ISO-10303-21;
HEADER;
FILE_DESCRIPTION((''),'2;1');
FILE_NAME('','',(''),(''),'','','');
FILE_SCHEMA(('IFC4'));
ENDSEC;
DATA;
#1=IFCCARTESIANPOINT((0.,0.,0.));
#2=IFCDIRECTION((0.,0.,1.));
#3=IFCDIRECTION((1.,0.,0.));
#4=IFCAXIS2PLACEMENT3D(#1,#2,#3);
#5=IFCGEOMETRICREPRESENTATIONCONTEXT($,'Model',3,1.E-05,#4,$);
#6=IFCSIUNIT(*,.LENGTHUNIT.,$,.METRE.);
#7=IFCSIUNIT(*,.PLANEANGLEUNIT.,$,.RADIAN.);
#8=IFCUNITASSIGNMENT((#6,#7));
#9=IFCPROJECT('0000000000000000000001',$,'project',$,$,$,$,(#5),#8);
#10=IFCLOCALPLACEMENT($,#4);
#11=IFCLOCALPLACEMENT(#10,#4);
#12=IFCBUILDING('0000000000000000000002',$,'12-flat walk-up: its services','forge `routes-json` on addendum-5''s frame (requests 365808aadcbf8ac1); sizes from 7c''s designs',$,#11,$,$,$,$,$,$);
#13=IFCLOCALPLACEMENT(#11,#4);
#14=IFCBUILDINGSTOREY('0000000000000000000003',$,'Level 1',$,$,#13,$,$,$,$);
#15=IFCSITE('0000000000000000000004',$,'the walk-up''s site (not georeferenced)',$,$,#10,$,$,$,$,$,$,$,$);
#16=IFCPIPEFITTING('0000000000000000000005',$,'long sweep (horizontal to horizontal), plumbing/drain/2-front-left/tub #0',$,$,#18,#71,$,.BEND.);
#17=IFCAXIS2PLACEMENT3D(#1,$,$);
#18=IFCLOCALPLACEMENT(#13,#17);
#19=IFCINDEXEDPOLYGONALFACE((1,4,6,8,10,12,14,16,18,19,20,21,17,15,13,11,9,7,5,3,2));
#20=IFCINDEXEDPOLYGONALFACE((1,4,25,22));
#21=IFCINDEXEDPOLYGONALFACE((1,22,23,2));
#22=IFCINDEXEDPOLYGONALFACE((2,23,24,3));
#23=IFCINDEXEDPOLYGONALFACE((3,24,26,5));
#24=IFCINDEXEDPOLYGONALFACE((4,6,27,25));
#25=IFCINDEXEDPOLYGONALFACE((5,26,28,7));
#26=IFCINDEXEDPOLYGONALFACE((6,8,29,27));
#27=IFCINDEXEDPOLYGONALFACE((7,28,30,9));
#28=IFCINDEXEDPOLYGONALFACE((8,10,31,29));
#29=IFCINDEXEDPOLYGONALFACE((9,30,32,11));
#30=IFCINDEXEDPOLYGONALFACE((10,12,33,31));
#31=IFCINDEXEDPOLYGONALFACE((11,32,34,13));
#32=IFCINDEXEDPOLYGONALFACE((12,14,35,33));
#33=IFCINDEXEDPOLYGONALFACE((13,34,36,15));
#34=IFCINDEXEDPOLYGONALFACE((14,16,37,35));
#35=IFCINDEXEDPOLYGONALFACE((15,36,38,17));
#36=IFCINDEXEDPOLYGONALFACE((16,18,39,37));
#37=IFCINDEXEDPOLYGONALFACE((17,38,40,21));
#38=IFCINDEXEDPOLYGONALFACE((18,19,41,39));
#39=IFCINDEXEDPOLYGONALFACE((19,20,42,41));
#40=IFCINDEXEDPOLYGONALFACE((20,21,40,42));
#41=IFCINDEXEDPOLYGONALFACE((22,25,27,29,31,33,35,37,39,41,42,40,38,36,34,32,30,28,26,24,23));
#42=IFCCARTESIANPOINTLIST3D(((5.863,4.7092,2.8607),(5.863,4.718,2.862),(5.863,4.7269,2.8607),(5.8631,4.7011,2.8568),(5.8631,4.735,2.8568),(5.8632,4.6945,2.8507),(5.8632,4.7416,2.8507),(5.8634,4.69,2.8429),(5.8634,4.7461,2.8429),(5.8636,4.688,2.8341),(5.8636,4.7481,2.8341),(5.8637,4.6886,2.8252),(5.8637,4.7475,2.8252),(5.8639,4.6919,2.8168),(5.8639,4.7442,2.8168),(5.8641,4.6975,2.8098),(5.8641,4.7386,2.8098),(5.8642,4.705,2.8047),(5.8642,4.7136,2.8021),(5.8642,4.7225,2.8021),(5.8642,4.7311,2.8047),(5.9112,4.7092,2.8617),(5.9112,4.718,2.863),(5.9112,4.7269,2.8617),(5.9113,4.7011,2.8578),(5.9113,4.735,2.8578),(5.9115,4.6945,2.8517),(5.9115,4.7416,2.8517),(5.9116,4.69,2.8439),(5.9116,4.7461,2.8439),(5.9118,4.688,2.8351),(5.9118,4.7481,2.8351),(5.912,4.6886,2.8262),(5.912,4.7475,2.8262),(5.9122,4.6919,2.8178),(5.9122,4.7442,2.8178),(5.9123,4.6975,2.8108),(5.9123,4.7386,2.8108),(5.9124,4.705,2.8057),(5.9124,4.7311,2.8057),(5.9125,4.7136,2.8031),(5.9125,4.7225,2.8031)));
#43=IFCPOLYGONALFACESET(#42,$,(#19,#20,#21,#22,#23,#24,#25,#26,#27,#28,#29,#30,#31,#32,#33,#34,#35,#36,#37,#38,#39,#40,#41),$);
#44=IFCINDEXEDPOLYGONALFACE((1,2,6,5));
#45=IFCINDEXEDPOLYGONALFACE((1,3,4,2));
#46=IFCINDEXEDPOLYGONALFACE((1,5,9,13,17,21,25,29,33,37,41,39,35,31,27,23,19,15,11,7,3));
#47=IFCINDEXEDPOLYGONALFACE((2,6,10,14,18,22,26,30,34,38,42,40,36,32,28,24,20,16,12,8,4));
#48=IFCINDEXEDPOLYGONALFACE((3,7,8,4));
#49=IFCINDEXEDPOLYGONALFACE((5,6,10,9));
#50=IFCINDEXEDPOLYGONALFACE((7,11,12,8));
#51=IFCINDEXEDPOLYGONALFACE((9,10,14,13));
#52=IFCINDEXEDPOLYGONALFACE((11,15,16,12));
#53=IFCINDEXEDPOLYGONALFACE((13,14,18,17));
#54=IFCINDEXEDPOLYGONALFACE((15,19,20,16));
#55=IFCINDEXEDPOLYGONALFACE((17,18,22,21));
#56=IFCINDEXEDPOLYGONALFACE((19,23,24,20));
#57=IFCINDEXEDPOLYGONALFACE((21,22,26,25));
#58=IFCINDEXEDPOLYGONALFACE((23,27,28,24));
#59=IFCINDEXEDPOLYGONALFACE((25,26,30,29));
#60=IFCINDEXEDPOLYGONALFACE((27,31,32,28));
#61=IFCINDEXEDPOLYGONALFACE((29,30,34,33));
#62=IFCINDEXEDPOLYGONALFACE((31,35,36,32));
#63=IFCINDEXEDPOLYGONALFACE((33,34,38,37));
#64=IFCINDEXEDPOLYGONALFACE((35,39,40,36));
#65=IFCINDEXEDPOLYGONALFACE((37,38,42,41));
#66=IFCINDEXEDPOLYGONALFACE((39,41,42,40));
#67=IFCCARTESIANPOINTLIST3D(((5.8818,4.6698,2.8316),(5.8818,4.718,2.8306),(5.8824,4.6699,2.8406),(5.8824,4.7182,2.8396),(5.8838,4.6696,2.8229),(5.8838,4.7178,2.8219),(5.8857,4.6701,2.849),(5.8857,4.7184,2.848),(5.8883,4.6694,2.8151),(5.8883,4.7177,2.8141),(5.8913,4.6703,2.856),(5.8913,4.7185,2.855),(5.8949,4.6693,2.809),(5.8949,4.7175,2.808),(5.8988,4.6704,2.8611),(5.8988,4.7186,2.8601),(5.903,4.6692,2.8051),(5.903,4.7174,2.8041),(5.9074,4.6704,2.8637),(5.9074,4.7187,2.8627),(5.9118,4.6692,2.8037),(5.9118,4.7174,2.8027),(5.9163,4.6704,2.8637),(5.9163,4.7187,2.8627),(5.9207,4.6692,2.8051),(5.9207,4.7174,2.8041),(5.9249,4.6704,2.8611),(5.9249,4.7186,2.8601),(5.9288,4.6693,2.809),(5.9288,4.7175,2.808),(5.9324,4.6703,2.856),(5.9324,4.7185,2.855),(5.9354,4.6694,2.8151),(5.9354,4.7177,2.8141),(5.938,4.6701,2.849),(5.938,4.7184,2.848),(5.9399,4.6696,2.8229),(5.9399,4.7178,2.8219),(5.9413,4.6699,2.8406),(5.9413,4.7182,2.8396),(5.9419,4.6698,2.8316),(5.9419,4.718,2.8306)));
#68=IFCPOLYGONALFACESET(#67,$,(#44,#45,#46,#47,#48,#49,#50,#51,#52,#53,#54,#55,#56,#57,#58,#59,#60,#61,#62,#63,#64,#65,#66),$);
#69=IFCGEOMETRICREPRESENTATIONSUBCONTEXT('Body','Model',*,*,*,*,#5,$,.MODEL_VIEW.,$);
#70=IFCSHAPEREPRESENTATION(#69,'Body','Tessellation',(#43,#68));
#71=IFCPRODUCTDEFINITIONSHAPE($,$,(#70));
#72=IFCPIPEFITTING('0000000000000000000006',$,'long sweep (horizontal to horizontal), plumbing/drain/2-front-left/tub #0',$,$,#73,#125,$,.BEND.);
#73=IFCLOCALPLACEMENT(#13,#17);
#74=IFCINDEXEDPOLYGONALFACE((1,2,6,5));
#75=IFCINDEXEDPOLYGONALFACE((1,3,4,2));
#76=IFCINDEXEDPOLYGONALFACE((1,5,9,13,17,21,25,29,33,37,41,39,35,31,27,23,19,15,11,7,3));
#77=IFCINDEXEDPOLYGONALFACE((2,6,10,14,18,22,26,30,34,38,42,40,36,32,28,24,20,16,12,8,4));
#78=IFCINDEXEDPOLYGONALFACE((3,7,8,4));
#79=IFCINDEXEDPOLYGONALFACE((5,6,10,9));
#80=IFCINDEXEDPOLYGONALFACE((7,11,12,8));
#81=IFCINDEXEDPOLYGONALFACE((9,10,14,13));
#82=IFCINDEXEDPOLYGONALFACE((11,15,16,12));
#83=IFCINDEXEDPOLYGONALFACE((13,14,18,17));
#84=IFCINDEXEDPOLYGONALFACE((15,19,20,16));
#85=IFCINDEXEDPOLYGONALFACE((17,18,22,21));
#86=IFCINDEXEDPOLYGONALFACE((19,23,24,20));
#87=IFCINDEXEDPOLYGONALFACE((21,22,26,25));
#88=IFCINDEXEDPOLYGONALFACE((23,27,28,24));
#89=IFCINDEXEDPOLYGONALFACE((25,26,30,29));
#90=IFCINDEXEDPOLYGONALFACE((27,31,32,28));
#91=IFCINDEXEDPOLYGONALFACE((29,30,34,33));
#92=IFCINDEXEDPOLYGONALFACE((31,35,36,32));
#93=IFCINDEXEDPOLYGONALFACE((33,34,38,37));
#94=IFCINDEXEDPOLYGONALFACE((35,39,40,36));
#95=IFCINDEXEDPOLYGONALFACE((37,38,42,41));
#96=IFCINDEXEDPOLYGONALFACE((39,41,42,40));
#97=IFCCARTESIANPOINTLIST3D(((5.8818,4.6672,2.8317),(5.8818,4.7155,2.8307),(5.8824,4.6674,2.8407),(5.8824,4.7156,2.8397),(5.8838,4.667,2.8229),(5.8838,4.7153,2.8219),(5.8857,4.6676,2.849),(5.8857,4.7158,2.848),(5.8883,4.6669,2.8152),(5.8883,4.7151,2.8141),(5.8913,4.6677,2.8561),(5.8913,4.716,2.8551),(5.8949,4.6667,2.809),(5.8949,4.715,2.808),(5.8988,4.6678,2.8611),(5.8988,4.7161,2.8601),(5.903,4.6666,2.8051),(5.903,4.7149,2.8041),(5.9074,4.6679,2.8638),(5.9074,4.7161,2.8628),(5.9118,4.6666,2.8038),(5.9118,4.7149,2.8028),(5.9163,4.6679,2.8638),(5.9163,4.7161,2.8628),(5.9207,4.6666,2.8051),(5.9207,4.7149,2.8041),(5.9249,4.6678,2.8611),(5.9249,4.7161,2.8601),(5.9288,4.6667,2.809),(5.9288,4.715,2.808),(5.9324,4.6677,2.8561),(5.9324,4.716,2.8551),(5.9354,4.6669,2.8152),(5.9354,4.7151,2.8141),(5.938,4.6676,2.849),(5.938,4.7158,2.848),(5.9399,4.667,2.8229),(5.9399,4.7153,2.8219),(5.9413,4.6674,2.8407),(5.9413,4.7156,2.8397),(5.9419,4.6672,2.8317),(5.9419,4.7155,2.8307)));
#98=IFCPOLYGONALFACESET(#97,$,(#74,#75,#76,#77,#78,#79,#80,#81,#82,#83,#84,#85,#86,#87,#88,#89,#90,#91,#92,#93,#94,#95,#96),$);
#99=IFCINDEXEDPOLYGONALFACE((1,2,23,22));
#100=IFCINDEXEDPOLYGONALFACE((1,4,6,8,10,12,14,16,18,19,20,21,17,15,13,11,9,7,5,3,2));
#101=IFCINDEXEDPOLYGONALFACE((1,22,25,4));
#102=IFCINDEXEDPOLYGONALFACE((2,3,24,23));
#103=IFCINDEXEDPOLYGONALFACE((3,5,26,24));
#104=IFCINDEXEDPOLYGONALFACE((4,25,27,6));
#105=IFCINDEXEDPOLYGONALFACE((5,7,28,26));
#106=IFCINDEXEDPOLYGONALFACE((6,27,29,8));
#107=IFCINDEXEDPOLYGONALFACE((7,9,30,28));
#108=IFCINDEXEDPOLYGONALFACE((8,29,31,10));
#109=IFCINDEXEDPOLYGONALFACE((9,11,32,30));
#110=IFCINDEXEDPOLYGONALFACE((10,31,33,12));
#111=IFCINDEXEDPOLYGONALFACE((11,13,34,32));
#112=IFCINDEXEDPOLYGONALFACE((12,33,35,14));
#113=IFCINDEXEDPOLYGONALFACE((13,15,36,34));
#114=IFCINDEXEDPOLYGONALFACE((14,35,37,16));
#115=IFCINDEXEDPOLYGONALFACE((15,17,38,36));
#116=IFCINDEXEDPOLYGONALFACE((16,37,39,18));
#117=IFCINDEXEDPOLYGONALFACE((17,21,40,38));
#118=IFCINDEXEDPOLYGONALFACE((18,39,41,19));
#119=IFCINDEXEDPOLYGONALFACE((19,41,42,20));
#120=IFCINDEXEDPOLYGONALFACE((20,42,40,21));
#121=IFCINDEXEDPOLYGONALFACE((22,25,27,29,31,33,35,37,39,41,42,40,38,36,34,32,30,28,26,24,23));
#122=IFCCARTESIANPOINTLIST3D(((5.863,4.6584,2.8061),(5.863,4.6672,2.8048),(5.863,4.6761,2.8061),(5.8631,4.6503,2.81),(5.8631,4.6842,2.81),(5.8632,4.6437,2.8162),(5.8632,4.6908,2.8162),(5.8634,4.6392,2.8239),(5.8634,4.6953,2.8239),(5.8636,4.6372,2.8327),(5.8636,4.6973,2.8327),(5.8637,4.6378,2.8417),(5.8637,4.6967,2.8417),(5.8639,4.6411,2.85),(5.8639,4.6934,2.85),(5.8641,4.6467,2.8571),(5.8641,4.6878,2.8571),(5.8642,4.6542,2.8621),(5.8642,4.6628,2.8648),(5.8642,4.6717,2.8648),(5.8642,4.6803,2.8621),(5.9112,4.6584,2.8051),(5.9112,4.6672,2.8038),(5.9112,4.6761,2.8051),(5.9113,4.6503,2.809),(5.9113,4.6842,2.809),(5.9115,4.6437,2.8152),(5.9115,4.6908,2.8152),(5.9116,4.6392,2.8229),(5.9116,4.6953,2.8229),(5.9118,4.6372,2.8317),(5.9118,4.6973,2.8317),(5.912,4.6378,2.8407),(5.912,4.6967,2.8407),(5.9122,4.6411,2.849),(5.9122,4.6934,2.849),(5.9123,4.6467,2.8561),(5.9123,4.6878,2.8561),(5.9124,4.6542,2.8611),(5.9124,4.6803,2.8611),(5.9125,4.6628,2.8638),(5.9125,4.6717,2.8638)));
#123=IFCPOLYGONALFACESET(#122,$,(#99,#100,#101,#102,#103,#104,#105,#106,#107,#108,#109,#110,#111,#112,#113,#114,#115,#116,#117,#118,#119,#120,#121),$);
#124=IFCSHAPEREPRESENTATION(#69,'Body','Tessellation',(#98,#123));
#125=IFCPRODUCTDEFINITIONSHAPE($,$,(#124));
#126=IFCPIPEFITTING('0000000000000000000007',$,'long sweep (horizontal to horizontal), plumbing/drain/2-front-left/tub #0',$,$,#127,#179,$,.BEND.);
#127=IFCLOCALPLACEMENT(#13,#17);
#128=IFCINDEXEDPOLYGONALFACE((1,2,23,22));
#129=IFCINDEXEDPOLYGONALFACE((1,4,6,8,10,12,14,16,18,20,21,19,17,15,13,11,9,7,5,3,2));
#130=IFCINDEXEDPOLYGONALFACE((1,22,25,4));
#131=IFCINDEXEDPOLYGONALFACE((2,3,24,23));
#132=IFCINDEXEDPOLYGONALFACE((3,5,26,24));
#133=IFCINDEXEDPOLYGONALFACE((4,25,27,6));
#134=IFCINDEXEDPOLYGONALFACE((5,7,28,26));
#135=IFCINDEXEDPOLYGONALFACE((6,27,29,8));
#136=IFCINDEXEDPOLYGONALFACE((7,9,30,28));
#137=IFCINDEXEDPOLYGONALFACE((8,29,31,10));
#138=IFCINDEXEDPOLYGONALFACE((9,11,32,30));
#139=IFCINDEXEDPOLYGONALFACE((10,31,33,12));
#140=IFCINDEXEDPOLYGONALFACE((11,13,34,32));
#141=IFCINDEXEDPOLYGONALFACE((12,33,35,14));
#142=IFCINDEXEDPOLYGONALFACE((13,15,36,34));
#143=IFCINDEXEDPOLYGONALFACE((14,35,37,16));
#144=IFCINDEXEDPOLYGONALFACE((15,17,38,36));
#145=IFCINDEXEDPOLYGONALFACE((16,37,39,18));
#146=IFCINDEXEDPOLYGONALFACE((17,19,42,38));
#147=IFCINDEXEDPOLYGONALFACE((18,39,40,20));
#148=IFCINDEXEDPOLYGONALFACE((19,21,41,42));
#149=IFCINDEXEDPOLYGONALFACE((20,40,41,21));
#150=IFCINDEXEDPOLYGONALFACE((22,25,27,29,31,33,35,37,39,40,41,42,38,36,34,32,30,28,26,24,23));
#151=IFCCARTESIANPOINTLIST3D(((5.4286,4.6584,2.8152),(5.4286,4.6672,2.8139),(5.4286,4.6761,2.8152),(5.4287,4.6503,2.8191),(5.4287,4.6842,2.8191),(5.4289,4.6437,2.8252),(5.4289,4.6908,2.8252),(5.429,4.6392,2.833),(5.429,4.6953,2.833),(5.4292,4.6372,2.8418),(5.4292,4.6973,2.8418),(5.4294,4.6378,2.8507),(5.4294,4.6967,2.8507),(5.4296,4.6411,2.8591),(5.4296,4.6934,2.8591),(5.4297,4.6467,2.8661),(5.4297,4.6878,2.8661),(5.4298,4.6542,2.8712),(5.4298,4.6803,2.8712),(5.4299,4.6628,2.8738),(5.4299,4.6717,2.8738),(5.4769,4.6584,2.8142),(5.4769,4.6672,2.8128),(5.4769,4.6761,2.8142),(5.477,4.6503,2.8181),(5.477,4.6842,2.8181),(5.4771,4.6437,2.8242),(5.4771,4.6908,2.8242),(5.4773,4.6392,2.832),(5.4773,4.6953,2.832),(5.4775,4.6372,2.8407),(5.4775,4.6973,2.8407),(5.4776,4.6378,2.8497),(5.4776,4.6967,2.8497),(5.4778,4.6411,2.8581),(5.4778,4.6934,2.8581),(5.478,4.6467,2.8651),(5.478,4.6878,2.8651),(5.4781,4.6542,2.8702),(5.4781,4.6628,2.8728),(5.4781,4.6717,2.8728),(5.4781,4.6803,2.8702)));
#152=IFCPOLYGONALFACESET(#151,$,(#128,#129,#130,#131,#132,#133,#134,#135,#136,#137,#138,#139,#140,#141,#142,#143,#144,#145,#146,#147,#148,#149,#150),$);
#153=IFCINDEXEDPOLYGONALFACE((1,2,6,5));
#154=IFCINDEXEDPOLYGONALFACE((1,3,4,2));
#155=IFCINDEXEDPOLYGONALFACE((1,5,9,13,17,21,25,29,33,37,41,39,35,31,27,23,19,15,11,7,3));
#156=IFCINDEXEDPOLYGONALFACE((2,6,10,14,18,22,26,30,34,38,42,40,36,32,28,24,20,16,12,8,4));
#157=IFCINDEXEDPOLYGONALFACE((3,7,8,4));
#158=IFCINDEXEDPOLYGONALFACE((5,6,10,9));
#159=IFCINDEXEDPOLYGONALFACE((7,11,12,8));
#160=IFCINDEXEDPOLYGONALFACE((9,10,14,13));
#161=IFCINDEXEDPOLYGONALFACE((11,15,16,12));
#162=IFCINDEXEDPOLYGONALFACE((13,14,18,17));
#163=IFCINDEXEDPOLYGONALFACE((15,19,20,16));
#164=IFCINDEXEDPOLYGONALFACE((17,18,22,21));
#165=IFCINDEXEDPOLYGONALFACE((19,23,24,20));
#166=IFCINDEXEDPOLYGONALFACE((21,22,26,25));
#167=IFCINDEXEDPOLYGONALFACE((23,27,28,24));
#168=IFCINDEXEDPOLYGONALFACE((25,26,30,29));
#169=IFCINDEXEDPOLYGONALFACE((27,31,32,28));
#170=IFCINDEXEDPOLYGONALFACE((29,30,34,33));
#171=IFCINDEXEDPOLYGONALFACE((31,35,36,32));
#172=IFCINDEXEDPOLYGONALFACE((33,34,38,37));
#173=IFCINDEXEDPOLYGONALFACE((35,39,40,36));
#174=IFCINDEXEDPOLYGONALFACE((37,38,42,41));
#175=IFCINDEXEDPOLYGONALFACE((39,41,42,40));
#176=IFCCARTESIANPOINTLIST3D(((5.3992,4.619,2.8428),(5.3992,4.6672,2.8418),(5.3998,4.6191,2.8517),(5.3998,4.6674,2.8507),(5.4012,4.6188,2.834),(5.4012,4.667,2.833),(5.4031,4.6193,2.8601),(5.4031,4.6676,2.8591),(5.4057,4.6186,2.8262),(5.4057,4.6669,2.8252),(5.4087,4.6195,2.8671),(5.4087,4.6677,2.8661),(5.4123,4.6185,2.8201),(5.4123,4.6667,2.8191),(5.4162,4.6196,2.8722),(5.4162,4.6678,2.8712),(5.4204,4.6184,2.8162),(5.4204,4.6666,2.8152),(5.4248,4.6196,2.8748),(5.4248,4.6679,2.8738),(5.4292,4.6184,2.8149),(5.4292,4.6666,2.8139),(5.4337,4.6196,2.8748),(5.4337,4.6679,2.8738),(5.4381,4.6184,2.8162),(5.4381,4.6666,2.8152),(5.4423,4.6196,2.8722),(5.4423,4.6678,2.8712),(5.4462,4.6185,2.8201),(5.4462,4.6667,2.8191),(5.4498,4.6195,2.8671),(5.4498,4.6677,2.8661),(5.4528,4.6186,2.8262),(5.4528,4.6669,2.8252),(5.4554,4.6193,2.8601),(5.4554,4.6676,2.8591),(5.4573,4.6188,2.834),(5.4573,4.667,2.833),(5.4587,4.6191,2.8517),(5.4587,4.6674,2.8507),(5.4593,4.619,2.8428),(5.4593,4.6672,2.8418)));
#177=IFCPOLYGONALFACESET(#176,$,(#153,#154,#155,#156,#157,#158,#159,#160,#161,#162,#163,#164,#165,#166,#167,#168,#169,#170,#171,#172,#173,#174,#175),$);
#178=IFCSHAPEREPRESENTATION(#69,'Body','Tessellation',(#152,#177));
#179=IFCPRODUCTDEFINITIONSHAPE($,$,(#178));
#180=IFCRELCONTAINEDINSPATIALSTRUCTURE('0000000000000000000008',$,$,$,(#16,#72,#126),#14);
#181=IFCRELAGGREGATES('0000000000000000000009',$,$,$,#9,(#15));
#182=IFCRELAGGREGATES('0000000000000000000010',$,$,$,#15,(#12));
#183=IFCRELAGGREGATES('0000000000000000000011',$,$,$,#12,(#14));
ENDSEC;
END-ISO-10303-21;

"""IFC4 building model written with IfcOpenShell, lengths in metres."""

from ifc_helpers import new_model, entity, si_unit, frame, origin_with_axes, place, context, subcontext, project, spatial, element, save


model = new_model("IFC4")

# Units and contexts
model_context = context("Model", 3, precision=1e-05, world=origin_with_axes())
body_context = subcontext(model_context, "Body", "Model", "MODEL_VIEW")
ifc_project = project(units=[si_unit("LENGTHUNIT", "METRE"), si_unit("PLANEANGLEUNIT", "RADIAN")], contexts=[model_context])

# Site, building, storey
site_placement = place(None, origin_with_axes())
site = spatial("IfcSite", under=ifc_project, at=site_placement, Name="the walk-up's site (not georeferenced)")
building_placement = place(site_placement, origin_with_axes())
building = spatial("IfcBuilding", under=site, at=building_placement, Name="12-flat walk-up: its services", Description="forge `routes-json` on addendum-5's frame (requests 365808aadcbf8ac1); sizes from 7c's designs")
storey_placement = place(building_placement, origin_with_axes())
storey = spatial("IfcBuildingStorey", under=building, at=storey_placement, Name="Level 1")

# Pipe fittings
pipe_fitting_1_placement = place(storey_placement, frame((5.8636, 4.718, 2.8319), z_axis=(0.0, 0.0, 1.0), x_axis=(1.0, 0.0, 0.0)))
element("IfcPipeFitting", 1, at=pipe_fitting_1_placement, inside=storey, Name="long sweep (horizontal to horizontal), plumbing/drain/2-front-left/tub #0", PredefinedType="BEND", context=body_context, shape_type="AdvancedSweptSolid", body=[
    entity("IfcSweptDiskSolid", entity("IfcPolyline", [entity("IfcCartesianPoint", [0.0, 0.0, 0.0]), entity("IfcCartesianPoint", [0.0482, 0.0, 0.001])]), 0.0302),
    entity("IfcSweptDiskSolid", entity("IfcPolyline", [entity("IfcCartesianPoint", [0.0482, 0.0, 0.001]), entity("IfcCartesianPoint", [0.0482, -0.0482, 0.002])]), 0.0302),
])
pipe_fitting_2_placement = place(storey_placement, frame((5.9118, 4.7155, 2.8329), z_axis=(0.0, 0.0, 1.0), x_axis=(1.0, 0.0, 0.0)))
element("IfcPipeFitting", 2, at=pipe_fitting_2_placement, inside=storey, Name="long sweep (horizontal to horizontal), plumbing/drain/2-front-left/tub #0", PredefinedType="BEND", context=body_context, shape_type="AdvancedSweptSolid", body=[
    entity("IfcSweptDiskSolid", entity("IfcPolyline", [entity("IfcCartesianPoint", [0.0, 0.0, 0.0]), entity("IfcCartesianPoint", [0.0, -0.0482, 0.001])]), 0.0302),
    entity("IfcSweptDiskSolid", entity("IfcPolyline", [entity("IfcCartesianPoint", [0.0, -0.0482, 0.001]), entity("IfcCartesianPoint", [-0.0482, -0.0482, 0.002])]), 0.0302),
])
pipe_fitting_3_placement = place(storey_placement, frame((5.4775, 4.6672, 2.843), z_axis=(0.0, 0.0, 1.0), x_axis=(1.0, 0.0, 0.0)))
element("IfcPipeFitting", 3, at=pipe_fitting_3_placement, inside=storey, Name="long sweep (horizontal to horizontal), plumbing/drain/2-front-left/tub #0", PredefinedType="BEND", context=body_context, shape_type="AdvancedSweptSolid", body=[
    entity("IfcSweptDiskSolid", entity("IfcPolyline", [entity("IfcCartesianPoint", [0.0, 0.0, 0.0]), entity("IfcCartesianPoint", [-0.0482, 0.0, 0.001])]), 0.0302),
    entity("IfcSweptDiskSolid", entity("IfcPolyline", [entity("IfcCartesianPoint", [-0.0482, 0.0, 0.001]), entity("IfcCartesianPoint", [-0.0482, -0.0482, 0.002])]), 0.0302),
])

save(model, "model.ifc")
